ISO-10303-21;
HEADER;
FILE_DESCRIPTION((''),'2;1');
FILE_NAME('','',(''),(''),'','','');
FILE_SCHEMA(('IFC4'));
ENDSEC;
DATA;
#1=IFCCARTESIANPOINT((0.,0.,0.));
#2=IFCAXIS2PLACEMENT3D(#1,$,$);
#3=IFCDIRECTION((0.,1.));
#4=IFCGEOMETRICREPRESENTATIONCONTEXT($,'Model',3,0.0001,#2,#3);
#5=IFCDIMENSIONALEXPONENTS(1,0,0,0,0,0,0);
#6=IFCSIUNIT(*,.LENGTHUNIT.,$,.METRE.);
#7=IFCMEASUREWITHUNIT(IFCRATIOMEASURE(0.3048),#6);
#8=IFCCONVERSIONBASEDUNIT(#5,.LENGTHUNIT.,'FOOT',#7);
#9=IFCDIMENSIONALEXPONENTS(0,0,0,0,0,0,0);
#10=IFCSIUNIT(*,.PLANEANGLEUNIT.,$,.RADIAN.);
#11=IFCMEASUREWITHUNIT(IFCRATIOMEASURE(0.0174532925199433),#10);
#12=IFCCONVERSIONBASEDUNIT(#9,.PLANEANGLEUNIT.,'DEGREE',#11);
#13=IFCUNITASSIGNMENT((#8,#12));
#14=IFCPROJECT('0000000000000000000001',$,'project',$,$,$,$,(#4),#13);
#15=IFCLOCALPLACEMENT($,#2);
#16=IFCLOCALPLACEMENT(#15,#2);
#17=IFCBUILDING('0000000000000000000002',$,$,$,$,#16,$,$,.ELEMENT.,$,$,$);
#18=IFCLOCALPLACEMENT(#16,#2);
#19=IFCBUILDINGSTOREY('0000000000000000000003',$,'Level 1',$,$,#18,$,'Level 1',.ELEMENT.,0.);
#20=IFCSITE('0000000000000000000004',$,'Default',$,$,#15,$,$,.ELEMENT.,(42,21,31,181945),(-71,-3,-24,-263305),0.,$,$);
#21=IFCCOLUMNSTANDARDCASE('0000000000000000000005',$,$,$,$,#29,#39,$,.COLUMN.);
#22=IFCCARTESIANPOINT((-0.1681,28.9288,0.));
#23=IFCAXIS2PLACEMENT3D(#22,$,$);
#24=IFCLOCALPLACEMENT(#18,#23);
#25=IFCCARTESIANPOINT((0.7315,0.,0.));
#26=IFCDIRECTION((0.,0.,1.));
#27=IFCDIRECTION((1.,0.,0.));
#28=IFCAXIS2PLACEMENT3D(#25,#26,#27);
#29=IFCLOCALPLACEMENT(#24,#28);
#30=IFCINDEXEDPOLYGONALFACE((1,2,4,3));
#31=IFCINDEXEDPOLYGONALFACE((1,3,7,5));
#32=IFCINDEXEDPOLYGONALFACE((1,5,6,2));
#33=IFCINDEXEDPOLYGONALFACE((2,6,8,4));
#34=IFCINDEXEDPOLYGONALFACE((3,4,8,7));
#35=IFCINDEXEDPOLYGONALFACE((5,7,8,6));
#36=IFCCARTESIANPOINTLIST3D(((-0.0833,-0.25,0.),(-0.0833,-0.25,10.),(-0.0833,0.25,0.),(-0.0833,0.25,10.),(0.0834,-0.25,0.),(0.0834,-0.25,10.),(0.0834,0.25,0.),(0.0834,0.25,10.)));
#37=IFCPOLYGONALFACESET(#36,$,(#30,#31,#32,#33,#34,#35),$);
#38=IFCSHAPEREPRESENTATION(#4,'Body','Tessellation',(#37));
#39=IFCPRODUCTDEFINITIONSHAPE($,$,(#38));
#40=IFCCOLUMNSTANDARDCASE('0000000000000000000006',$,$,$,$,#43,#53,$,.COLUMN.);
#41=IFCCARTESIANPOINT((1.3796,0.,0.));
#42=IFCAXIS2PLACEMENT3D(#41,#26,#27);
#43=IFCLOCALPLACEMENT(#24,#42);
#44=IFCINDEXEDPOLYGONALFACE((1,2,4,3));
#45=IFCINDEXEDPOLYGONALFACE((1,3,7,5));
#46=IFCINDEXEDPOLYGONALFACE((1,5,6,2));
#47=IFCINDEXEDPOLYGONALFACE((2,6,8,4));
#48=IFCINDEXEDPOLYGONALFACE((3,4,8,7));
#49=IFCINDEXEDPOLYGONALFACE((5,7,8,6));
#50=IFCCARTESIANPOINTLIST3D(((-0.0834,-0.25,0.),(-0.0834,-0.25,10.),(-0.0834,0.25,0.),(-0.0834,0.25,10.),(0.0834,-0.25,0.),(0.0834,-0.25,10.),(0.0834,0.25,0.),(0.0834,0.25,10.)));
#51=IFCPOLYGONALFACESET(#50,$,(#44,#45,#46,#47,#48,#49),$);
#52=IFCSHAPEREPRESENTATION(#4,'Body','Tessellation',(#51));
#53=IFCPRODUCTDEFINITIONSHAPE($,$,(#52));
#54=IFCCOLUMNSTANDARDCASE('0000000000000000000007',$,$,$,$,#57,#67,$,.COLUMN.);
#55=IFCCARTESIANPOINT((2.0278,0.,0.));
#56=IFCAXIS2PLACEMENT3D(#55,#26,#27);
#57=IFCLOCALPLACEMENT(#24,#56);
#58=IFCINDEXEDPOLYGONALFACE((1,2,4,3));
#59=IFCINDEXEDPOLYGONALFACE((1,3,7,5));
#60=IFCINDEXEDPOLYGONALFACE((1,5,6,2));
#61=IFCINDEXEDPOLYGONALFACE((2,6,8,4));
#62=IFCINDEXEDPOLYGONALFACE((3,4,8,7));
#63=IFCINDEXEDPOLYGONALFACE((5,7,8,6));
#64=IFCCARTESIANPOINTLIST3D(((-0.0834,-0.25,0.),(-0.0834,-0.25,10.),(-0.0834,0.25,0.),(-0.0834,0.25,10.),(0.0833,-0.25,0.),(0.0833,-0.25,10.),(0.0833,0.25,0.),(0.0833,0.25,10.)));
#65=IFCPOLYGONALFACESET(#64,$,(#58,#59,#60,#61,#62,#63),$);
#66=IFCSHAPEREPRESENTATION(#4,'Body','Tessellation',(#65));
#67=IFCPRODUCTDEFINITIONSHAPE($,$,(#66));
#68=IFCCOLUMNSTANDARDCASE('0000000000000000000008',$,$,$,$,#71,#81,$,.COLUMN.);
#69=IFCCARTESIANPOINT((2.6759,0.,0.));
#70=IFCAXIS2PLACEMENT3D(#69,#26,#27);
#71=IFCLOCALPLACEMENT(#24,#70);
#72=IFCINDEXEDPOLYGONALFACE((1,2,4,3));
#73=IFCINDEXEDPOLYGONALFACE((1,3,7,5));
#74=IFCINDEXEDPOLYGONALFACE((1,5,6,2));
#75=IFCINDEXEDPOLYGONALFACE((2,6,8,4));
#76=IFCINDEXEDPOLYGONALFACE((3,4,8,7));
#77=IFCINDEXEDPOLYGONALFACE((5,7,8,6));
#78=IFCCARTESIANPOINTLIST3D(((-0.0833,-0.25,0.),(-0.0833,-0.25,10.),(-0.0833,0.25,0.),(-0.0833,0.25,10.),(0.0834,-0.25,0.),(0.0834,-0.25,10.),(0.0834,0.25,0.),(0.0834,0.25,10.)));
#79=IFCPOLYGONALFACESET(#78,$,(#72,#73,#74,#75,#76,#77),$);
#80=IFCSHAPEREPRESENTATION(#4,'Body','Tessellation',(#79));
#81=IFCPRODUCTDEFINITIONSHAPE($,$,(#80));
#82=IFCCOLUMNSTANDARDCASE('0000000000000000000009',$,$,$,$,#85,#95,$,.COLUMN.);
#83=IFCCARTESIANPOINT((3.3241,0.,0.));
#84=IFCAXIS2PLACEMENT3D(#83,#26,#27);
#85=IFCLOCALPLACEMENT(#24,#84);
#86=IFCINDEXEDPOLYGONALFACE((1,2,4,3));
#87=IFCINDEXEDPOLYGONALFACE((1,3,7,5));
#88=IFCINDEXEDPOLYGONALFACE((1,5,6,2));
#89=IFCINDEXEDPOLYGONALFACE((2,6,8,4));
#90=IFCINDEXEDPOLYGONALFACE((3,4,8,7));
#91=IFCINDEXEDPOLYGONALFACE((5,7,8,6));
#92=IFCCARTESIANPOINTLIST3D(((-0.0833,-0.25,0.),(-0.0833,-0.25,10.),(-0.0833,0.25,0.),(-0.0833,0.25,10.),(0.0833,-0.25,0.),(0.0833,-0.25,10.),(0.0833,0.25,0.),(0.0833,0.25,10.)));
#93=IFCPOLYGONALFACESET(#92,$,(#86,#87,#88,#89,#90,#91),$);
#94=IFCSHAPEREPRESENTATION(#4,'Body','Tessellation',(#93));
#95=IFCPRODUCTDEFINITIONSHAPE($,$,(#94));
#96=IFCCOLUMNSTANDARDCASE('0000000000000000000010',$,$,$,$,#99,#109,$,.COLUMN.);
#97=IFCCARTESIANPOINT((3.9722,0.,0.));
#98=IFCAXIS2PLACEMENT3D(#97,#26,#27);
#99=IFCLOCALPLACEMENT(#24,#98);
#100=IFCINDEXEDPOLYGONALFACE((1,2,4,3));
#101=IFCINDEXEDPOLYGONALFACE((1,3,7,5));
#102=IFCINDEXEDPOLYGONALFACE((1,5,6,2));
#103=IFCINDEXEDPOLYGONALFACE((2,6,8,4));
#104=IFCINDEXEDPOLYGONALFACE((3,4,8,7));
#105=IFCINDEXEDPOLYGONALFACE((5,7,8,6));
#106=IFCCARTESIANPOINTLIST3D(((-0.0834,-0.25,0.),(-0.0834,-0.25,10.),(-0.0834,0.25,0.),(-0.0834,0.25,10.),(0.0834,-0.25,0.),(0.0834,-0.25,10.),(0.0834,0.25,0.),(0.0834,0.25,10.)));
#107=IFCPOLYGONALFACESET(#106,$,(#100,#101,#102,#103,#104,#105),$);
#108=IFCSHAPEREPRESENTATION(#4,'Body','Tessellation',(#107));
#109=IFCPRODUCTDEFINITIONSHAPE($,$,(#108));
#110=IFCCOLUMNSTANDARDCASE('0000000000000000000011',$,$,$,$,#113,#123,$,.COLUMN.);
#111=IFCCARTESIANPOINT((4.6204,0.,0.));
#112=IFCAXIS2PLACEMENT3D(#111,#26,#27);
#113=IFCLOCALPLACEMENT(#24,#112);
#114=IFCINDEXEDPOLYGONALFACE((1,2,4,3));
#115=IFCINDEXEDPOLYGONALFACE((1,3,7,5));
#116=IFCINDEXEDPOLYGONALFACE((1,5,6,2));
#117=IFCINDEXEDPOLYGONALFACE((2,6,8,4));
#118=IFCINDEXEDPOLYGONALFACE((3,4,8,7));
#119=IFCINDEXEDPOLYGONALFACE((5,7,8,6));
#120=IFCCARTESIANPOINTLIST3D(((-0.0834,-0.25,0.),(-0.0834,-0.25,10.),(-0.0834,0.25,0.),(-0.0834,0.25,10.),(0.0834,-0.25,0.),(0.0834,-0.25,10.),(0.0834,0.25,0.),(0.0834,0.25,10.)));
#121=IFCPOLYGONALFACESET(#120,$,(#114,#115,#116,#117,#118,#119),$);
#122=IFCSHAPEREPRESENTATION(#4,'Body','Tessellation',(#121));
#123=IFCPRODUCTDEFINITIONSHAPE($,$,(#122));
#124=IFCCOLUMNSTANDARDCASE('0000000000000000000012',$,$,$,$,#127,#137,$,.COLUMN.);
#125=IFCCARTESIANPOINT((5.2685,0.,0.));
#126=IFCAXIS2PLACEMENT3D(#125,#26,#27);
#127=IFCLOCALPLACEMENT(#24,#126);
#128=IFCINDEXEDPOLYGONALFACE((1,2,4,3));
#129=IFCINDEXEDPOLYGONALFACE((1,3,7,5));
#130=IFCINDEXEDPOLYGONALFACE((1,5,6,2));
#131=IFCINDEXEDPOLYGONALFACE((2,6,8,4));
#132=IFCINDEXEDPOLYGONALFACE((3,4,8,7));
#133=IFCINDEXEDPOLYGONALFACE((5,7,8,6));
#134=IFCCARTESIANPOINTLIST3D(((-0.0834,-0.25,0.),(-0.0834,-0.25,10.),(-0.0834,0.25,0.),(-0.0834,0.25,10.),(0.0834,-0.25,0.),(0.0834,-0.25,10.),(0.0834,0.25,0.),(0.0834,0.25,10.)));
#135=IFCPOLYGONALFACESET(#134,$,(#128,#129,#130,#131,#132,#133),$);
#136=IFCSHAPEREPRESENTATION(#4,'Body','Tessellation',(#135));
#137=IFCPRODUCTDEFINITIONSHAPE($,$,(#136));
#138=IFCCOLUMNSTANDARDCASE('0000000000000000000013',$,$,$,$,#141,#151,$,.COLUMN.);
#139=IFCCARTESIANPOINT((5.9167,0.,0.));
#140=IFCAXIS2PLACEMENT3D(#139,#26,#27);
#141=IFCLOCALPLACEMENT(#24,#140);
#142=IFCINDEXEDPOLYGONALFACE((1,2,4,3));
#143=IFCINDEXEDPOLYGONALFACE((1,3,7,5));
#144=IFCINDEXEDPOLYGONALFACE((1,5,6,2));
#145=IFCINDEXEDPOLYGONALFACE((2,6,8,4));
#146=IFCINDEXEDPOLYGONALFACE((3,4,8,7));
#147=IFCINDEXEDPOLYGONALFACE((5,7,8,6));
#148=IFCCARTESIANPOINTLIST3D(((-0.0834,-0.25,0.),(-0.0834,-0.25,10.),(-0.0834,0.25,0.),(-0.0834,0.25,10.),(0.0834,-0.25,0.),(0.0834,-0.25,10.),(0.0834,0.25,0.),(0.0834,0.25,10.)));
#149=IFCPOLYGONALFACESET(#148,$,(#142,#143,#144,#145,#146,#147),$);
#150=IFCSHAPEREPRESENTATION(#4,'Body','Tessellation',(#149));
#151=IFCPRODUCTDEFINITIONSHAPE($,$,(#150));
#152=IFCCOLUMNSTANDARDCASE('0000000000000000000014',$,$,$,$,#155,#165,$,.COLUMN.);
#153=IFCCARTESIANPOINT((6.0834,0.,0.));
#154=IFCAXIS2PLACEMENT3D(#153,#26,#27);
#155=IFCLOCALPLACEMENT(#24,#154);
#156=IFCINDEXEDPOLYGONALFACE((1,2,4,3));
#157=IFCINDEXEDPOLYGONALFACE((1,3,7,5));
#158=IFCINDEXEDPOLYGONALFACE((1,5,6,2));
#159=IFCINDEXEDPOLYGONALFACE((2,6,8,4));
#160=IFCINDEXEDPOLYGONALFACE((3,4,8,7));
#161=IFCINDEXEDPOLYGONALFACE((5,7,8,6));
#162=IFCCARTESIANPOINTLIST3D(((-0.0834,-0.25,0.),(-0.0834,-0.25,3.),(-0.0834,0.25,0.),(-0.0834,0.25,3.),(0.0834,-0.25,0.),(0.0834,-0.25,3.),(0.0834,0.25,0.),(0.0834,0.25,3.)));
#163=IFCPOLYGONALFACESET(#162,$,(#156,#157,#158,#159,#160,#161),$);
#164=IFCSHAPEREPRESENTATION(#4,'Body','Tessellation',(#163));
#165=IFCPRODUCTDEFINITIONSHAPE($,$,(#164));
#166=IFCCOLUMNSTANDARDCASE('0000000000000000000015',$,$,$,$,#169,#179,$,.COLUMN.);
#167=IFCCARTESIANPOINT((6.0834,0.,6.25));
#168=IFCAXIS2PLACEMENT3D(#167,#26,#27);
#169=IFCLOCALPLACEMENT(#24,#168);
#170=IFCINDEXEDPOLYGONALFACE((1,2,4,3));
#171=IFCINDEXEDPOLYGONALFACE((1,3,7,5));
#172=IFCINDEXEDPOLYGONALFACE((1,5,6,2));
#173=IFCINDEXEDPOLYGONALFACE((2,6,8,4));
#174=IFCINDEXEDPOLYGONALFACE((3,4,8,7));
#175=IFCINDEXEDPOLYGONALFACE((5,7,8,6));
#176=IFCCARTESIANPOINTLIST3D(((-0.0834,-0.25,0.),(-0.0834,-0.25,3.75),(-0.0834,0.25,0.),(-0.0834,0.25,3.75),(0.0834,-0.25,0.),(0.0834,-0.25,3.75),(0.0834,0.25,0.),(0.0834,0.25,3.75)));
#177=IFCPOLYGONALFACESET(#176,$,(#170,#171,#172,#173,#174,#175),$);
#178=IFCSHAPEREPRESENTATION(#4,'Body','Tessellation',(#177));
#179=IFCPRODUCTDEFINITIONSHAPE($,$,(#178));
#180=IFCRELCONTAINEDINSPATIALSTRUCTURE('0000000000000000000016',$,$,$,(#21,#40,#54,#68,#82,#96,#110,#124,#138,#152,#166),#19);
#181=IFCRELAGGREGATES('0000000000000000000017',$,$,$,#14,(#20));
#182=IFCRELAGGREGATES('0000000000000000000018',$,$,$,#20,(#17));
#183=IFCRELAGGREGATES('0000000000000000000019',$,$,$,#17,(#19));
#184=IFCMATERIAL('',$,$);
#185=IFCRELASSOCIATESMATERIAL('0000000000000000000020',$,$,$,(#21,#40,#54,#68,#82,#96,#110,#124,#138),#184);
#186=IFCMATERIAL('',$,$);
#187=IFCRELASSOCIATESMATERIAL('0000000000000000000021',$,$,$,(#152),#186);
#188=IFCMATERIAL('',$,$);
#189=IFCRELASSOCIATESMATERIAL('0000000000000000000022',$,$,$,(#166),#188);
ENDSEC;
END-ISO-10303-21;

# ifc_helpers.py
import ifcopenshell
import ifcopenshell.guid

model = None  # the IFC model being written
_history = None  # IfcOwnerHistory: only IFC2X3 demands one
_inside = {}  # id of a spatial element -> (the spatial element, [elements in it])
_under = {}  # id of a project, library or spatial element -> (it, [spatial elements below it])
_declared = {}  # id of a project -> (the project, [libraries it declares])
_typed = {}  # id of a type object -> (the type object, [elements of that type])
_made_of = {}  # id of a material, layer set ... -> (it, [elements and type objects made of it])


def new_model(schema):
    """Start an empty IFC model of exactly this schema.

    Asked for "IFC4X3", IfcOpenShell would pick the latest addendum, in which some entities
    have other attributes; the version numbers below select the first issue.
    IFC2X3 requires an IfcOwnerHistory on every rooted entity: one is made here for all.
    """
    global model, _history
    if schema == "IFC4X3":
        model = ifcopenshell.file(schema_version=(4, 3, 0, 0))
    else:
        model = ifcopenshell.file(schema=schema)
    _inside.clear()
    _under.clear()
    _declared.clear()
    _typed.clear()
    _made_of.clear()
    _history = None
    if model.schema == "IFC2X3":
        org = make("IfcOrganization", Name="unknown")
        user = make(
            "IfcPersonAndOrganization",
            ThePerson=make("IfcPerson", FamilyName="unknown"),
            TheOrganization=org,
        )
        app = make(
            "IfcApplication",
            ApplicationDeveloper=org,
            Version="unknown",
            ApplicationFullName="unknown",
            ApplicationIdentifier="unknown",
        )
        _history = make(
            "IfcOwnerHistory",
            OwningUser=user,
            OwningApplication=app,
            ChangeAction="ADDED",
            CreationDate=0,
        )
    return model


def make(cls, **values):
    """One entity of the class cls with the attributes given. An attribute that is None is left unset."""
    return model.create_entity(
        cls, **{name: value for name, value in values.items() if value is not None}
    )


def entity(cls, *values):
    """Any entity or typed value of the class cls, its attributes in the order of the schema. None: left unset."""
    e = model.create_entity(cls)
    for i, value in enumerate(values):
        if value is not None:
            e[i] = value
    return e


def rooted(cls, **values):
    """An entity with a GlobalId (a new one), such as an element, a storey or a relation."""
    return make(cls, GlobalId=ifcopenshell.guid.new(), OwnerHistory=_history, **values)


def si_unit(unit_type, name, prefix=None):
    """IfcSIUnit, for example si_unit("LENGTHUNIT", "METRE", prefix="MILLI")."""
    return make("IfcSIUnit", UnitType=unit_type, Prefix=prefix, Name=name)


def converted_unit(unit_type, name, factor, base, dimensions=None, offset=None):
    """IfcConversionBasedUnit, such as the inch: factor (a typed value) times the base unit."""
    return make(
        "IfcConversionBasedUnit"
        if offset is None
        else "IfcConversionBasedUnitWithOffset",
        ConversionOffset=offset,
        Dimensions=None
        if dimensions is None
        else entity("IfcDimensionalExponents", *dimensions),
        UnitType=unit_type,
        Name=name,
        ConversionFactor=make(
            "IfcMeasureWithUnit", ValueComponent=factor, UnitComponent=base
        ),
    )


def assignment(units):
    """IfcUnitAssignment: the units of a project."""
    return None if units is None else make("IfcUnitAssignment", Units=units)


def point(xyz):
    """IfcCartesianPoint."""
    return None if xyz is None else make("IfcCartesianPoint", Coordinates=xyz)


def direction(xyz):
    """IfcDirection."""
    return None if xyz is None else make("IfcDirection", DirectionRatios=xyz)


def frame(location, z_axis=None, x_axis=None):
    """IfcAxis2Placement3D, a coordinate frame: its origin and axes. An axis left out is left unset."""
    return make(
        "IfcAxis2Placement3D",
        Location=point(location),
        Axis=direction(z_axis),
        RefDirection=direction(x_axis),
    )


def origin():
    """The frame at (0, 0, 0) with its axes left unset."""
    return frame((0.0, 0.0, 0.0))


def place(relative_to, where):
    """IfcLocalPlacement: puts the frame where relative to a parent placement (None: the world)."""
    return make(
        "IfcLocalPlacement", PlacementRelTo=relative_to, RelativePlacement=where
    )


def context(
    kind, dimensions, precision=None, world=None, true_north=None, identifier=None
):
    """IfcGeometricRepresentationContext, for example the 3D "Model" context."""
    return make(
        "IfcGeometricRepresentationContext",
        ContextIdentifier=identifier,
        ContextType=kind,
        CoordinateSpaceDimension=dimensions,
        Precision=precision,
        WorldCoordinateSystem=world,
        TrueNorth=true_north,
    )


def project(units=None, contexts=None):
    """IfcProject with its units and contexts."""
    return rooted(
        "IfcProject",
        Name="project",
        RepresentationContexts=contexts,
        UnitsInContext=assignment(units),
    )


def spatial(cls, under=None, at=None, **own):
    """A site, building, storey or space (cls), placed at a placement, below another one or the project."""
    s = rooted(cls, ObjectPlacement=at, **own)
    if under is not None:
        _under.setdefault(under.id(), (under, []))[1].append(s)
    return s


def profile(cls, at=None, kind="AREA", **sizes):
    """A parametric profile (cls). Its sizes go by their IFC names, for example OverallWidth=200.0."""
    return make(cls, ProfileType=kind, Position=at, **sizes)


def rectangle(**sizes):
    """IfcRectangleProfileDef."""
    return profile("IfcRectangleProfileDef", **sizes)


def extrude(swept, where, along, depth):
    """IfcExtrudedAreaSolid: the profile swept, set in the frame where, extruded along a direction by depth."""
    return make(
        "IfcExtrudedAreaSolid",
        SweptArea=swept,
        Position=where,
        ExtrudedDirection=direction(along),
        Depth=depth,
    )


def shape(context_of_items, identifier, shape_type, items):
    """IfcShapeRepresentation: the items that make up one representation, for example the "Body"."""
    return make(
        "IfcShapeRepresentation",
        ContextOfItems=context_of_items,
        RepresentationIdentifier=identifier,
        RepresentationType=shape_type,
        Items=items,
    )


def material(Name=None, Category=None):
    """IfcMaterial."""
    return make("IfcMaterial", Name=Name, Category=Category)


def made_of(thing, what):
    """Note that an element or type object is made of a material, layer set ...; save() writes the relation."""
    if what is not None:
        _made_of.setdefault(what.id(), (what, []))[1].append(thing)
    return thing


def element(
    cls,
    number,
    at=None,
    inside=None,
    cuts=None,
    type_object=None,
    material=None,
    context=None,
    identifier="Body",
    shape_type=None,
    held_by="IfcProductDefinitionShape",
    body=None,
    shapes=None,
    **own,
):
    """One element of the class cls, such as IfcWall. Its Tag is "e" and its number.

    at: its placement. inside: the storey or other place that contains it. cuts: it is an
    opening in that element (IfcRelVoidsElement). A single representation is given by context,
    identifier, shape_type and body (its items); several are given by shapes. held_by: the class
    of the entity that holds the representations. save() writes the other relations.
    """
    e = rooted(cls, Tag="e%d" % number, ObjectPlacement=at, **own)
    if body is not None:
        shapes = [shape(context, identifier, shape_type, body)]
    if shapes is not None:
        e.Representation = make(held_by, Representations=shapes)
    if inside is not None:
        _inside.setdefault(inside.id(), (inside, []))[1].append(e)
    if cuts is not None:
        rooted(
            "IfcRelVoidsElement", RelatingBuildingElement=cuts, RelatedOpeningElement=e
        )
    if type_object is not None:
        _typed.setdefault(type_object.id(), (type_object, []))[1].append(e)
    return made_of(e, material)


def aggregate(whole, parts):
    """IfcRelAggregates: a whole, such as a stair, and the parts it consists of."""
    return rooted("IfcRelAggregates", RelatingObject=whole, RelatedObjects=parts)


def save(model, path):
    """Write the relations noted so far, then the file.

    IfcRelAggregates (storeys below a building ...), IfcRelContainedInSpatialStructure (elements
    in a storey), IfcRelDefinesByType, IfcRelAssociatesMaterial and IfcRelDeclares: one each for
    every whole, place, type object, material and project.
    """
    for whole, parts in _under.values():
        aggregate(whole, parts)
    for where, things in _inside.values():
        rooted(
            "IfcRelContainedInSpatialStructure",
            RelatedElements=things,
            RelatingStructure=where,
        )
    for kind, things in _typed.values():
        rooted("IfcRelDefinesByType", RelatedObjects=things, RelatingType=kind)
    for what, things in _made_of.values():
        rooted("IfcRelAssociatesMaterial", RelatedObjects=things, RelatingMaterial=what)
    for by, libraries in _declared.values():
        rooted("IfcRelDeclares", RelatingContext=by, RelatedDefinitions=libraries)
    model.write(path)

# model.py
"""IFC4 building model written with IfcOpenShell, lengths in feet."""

from ifc_helpers import new_model, entity, si_unit, converted_unit, direction, frame, origin, place, context, project, spatial, rectangle, extrude, material, element, save


model = new_model("IFC4")

# Units and contexts
model_context = context("Model", 3, precision=0.0001, world=origin(), true_north=direction((0.0, 1.0)))
ifc_project = project(units=[converted_unit("LENGTHUNIT", "FOOT", entity("IfcRatioMeasure", 0.3048), si_unit("LENGTHUNIT", "METRE"), dimensions=[1, 0, 0, 0, 0, 0, 0]), converted_unit("PLANEANGLEUNIT", "DEGREE", entity("IfcRatioMeasure", 0.0174532925199433), si_unit("PLANEANGLEUNIT", "RADIAN"), dimensions=[0, 0, 0, 0, 0, 0, 0])], contexts=[model_context])

# Site, building, storey
site_placement = place(None, origin())
site = spatial("IfcSite", under=ifc_project, at=site_placement, Name="Default", CompositionType="ELEMENT", RefLatitude=(42, 21, 31, 181945), RefLongitude=(-71, -3, -24, -263305), RefElevation=0.0)
building_placement = place(site_placement, origin())
building = spatial("IfcBuilding", under=site, at=building_placement, CompositionType="ELEMENT")
storey_placement = place(building_placement, origin())
storey = spatial("IfcBuildingStorey", under=building, at=storey_placement, Name="Level 1", LongName="Level 1", CompositionType="ELEMENT", Elevation=0.0)

# Columns
ifc_material_1 = material(Name="")
placement = place(storey_placement, frame((-0.1681, 28.9288, 0.0)))
for number, where, z_axis, x_axis in (
    (1, (0.7315, 0.0, 0.0), (0.0, 0.0, 1.0), (1.0, 0.0, 0.0)),
    (2, (1.3796, 0.0, 0.0), (0.0, 0.0, 1.0), (1.0, 0.0, 0.0)),
    (3, (2.0278, 0.0, 0.0), (0.0, 0.0, 1.0), (1.0, 0.0, 0.0)),
    (4, (2.6759, 0.0, 0.0), (0.0, 0.0, 1.0), (1.0, 0.0, 0.0)),
    (5, (3.3241, 0.0, 0.0), (0.0, 0.0, 1.0), (1.0, 0.0, 0.0)),
    (6, (3.9722, 0.0, 0.0), (0.0, 0.0, 1.0), (1.0, 0.0, 0.0)),
    (7, (4.6204, 0.0, 0.0), (0.0, 0.0, 1.0), (1.0, 0.0, 0.0)),
    (8, (5.2685, 0.0, 0.0), (0.0, 0.0, 1.0), (1.0, 0.0, 0.0)),
    (9, (5.9167, 0.0, 0.0), (0.0, 0.0, 1.0), (1.0, 0.0, 0.0)),
):
    element("IfcColumnStandardCase", number, at=place(placement, frame(where, z_axis=z_axis, x_axis=x_axis)), inside=storey, material=ifc_material_1, PredefinedType="COLUMN", context=model_context, shape_type="SweptSolid", body=[
        extrude(rectangle(XDim=0.1667, YDim=0.5), origin(), (0.0, 0.0, 1.0), 10.0),
    ])
ifc_material_2 = material(Name="")
for number, where, z_axis, x_axis in (
    (10, (6.0834, 0.0, 0.0), (0.0, 0.0, 1.0), (1.0, 0.0, 0.0)),
):
    element("IfcColumnStandardCase", number, at=place(placement, frame(where, z_axis=z_axis, x_axis=x_axis)), inside=storey, material=ifc_material_2, PredefinedType="COLUMN", context=model_context, shape_type="SweptSolid", body=[
        extrude(rectangle(XDim=0.1667, YDim=0.5), origin(), (0.0, 0.0, 1.0), 3.0),
    ])
ifc_material_3 = material(Name="")
for number, where, z_axis, x_axis in (
    (11, (6.0834, 0.0, 6.25), (0.0, 0.0, 1.0), (1.0, 0.0, 0.0)),
):
    element("IfcColumnStandardCase", number, at=place(placement, frame(where, z_axis=z_axis, x_axis=x_axis)), inside=storey, material=ifc_material_3, PredefinedType="COLUMN", context=model_context, shape_type="SweptSolid", body=[
        extrude(rectangle(XDim=0.1667, YDim=0.5), origin(), (0.0, 0.0, 1.0), 3.75),
    ])

save(model, "model.ifc")
